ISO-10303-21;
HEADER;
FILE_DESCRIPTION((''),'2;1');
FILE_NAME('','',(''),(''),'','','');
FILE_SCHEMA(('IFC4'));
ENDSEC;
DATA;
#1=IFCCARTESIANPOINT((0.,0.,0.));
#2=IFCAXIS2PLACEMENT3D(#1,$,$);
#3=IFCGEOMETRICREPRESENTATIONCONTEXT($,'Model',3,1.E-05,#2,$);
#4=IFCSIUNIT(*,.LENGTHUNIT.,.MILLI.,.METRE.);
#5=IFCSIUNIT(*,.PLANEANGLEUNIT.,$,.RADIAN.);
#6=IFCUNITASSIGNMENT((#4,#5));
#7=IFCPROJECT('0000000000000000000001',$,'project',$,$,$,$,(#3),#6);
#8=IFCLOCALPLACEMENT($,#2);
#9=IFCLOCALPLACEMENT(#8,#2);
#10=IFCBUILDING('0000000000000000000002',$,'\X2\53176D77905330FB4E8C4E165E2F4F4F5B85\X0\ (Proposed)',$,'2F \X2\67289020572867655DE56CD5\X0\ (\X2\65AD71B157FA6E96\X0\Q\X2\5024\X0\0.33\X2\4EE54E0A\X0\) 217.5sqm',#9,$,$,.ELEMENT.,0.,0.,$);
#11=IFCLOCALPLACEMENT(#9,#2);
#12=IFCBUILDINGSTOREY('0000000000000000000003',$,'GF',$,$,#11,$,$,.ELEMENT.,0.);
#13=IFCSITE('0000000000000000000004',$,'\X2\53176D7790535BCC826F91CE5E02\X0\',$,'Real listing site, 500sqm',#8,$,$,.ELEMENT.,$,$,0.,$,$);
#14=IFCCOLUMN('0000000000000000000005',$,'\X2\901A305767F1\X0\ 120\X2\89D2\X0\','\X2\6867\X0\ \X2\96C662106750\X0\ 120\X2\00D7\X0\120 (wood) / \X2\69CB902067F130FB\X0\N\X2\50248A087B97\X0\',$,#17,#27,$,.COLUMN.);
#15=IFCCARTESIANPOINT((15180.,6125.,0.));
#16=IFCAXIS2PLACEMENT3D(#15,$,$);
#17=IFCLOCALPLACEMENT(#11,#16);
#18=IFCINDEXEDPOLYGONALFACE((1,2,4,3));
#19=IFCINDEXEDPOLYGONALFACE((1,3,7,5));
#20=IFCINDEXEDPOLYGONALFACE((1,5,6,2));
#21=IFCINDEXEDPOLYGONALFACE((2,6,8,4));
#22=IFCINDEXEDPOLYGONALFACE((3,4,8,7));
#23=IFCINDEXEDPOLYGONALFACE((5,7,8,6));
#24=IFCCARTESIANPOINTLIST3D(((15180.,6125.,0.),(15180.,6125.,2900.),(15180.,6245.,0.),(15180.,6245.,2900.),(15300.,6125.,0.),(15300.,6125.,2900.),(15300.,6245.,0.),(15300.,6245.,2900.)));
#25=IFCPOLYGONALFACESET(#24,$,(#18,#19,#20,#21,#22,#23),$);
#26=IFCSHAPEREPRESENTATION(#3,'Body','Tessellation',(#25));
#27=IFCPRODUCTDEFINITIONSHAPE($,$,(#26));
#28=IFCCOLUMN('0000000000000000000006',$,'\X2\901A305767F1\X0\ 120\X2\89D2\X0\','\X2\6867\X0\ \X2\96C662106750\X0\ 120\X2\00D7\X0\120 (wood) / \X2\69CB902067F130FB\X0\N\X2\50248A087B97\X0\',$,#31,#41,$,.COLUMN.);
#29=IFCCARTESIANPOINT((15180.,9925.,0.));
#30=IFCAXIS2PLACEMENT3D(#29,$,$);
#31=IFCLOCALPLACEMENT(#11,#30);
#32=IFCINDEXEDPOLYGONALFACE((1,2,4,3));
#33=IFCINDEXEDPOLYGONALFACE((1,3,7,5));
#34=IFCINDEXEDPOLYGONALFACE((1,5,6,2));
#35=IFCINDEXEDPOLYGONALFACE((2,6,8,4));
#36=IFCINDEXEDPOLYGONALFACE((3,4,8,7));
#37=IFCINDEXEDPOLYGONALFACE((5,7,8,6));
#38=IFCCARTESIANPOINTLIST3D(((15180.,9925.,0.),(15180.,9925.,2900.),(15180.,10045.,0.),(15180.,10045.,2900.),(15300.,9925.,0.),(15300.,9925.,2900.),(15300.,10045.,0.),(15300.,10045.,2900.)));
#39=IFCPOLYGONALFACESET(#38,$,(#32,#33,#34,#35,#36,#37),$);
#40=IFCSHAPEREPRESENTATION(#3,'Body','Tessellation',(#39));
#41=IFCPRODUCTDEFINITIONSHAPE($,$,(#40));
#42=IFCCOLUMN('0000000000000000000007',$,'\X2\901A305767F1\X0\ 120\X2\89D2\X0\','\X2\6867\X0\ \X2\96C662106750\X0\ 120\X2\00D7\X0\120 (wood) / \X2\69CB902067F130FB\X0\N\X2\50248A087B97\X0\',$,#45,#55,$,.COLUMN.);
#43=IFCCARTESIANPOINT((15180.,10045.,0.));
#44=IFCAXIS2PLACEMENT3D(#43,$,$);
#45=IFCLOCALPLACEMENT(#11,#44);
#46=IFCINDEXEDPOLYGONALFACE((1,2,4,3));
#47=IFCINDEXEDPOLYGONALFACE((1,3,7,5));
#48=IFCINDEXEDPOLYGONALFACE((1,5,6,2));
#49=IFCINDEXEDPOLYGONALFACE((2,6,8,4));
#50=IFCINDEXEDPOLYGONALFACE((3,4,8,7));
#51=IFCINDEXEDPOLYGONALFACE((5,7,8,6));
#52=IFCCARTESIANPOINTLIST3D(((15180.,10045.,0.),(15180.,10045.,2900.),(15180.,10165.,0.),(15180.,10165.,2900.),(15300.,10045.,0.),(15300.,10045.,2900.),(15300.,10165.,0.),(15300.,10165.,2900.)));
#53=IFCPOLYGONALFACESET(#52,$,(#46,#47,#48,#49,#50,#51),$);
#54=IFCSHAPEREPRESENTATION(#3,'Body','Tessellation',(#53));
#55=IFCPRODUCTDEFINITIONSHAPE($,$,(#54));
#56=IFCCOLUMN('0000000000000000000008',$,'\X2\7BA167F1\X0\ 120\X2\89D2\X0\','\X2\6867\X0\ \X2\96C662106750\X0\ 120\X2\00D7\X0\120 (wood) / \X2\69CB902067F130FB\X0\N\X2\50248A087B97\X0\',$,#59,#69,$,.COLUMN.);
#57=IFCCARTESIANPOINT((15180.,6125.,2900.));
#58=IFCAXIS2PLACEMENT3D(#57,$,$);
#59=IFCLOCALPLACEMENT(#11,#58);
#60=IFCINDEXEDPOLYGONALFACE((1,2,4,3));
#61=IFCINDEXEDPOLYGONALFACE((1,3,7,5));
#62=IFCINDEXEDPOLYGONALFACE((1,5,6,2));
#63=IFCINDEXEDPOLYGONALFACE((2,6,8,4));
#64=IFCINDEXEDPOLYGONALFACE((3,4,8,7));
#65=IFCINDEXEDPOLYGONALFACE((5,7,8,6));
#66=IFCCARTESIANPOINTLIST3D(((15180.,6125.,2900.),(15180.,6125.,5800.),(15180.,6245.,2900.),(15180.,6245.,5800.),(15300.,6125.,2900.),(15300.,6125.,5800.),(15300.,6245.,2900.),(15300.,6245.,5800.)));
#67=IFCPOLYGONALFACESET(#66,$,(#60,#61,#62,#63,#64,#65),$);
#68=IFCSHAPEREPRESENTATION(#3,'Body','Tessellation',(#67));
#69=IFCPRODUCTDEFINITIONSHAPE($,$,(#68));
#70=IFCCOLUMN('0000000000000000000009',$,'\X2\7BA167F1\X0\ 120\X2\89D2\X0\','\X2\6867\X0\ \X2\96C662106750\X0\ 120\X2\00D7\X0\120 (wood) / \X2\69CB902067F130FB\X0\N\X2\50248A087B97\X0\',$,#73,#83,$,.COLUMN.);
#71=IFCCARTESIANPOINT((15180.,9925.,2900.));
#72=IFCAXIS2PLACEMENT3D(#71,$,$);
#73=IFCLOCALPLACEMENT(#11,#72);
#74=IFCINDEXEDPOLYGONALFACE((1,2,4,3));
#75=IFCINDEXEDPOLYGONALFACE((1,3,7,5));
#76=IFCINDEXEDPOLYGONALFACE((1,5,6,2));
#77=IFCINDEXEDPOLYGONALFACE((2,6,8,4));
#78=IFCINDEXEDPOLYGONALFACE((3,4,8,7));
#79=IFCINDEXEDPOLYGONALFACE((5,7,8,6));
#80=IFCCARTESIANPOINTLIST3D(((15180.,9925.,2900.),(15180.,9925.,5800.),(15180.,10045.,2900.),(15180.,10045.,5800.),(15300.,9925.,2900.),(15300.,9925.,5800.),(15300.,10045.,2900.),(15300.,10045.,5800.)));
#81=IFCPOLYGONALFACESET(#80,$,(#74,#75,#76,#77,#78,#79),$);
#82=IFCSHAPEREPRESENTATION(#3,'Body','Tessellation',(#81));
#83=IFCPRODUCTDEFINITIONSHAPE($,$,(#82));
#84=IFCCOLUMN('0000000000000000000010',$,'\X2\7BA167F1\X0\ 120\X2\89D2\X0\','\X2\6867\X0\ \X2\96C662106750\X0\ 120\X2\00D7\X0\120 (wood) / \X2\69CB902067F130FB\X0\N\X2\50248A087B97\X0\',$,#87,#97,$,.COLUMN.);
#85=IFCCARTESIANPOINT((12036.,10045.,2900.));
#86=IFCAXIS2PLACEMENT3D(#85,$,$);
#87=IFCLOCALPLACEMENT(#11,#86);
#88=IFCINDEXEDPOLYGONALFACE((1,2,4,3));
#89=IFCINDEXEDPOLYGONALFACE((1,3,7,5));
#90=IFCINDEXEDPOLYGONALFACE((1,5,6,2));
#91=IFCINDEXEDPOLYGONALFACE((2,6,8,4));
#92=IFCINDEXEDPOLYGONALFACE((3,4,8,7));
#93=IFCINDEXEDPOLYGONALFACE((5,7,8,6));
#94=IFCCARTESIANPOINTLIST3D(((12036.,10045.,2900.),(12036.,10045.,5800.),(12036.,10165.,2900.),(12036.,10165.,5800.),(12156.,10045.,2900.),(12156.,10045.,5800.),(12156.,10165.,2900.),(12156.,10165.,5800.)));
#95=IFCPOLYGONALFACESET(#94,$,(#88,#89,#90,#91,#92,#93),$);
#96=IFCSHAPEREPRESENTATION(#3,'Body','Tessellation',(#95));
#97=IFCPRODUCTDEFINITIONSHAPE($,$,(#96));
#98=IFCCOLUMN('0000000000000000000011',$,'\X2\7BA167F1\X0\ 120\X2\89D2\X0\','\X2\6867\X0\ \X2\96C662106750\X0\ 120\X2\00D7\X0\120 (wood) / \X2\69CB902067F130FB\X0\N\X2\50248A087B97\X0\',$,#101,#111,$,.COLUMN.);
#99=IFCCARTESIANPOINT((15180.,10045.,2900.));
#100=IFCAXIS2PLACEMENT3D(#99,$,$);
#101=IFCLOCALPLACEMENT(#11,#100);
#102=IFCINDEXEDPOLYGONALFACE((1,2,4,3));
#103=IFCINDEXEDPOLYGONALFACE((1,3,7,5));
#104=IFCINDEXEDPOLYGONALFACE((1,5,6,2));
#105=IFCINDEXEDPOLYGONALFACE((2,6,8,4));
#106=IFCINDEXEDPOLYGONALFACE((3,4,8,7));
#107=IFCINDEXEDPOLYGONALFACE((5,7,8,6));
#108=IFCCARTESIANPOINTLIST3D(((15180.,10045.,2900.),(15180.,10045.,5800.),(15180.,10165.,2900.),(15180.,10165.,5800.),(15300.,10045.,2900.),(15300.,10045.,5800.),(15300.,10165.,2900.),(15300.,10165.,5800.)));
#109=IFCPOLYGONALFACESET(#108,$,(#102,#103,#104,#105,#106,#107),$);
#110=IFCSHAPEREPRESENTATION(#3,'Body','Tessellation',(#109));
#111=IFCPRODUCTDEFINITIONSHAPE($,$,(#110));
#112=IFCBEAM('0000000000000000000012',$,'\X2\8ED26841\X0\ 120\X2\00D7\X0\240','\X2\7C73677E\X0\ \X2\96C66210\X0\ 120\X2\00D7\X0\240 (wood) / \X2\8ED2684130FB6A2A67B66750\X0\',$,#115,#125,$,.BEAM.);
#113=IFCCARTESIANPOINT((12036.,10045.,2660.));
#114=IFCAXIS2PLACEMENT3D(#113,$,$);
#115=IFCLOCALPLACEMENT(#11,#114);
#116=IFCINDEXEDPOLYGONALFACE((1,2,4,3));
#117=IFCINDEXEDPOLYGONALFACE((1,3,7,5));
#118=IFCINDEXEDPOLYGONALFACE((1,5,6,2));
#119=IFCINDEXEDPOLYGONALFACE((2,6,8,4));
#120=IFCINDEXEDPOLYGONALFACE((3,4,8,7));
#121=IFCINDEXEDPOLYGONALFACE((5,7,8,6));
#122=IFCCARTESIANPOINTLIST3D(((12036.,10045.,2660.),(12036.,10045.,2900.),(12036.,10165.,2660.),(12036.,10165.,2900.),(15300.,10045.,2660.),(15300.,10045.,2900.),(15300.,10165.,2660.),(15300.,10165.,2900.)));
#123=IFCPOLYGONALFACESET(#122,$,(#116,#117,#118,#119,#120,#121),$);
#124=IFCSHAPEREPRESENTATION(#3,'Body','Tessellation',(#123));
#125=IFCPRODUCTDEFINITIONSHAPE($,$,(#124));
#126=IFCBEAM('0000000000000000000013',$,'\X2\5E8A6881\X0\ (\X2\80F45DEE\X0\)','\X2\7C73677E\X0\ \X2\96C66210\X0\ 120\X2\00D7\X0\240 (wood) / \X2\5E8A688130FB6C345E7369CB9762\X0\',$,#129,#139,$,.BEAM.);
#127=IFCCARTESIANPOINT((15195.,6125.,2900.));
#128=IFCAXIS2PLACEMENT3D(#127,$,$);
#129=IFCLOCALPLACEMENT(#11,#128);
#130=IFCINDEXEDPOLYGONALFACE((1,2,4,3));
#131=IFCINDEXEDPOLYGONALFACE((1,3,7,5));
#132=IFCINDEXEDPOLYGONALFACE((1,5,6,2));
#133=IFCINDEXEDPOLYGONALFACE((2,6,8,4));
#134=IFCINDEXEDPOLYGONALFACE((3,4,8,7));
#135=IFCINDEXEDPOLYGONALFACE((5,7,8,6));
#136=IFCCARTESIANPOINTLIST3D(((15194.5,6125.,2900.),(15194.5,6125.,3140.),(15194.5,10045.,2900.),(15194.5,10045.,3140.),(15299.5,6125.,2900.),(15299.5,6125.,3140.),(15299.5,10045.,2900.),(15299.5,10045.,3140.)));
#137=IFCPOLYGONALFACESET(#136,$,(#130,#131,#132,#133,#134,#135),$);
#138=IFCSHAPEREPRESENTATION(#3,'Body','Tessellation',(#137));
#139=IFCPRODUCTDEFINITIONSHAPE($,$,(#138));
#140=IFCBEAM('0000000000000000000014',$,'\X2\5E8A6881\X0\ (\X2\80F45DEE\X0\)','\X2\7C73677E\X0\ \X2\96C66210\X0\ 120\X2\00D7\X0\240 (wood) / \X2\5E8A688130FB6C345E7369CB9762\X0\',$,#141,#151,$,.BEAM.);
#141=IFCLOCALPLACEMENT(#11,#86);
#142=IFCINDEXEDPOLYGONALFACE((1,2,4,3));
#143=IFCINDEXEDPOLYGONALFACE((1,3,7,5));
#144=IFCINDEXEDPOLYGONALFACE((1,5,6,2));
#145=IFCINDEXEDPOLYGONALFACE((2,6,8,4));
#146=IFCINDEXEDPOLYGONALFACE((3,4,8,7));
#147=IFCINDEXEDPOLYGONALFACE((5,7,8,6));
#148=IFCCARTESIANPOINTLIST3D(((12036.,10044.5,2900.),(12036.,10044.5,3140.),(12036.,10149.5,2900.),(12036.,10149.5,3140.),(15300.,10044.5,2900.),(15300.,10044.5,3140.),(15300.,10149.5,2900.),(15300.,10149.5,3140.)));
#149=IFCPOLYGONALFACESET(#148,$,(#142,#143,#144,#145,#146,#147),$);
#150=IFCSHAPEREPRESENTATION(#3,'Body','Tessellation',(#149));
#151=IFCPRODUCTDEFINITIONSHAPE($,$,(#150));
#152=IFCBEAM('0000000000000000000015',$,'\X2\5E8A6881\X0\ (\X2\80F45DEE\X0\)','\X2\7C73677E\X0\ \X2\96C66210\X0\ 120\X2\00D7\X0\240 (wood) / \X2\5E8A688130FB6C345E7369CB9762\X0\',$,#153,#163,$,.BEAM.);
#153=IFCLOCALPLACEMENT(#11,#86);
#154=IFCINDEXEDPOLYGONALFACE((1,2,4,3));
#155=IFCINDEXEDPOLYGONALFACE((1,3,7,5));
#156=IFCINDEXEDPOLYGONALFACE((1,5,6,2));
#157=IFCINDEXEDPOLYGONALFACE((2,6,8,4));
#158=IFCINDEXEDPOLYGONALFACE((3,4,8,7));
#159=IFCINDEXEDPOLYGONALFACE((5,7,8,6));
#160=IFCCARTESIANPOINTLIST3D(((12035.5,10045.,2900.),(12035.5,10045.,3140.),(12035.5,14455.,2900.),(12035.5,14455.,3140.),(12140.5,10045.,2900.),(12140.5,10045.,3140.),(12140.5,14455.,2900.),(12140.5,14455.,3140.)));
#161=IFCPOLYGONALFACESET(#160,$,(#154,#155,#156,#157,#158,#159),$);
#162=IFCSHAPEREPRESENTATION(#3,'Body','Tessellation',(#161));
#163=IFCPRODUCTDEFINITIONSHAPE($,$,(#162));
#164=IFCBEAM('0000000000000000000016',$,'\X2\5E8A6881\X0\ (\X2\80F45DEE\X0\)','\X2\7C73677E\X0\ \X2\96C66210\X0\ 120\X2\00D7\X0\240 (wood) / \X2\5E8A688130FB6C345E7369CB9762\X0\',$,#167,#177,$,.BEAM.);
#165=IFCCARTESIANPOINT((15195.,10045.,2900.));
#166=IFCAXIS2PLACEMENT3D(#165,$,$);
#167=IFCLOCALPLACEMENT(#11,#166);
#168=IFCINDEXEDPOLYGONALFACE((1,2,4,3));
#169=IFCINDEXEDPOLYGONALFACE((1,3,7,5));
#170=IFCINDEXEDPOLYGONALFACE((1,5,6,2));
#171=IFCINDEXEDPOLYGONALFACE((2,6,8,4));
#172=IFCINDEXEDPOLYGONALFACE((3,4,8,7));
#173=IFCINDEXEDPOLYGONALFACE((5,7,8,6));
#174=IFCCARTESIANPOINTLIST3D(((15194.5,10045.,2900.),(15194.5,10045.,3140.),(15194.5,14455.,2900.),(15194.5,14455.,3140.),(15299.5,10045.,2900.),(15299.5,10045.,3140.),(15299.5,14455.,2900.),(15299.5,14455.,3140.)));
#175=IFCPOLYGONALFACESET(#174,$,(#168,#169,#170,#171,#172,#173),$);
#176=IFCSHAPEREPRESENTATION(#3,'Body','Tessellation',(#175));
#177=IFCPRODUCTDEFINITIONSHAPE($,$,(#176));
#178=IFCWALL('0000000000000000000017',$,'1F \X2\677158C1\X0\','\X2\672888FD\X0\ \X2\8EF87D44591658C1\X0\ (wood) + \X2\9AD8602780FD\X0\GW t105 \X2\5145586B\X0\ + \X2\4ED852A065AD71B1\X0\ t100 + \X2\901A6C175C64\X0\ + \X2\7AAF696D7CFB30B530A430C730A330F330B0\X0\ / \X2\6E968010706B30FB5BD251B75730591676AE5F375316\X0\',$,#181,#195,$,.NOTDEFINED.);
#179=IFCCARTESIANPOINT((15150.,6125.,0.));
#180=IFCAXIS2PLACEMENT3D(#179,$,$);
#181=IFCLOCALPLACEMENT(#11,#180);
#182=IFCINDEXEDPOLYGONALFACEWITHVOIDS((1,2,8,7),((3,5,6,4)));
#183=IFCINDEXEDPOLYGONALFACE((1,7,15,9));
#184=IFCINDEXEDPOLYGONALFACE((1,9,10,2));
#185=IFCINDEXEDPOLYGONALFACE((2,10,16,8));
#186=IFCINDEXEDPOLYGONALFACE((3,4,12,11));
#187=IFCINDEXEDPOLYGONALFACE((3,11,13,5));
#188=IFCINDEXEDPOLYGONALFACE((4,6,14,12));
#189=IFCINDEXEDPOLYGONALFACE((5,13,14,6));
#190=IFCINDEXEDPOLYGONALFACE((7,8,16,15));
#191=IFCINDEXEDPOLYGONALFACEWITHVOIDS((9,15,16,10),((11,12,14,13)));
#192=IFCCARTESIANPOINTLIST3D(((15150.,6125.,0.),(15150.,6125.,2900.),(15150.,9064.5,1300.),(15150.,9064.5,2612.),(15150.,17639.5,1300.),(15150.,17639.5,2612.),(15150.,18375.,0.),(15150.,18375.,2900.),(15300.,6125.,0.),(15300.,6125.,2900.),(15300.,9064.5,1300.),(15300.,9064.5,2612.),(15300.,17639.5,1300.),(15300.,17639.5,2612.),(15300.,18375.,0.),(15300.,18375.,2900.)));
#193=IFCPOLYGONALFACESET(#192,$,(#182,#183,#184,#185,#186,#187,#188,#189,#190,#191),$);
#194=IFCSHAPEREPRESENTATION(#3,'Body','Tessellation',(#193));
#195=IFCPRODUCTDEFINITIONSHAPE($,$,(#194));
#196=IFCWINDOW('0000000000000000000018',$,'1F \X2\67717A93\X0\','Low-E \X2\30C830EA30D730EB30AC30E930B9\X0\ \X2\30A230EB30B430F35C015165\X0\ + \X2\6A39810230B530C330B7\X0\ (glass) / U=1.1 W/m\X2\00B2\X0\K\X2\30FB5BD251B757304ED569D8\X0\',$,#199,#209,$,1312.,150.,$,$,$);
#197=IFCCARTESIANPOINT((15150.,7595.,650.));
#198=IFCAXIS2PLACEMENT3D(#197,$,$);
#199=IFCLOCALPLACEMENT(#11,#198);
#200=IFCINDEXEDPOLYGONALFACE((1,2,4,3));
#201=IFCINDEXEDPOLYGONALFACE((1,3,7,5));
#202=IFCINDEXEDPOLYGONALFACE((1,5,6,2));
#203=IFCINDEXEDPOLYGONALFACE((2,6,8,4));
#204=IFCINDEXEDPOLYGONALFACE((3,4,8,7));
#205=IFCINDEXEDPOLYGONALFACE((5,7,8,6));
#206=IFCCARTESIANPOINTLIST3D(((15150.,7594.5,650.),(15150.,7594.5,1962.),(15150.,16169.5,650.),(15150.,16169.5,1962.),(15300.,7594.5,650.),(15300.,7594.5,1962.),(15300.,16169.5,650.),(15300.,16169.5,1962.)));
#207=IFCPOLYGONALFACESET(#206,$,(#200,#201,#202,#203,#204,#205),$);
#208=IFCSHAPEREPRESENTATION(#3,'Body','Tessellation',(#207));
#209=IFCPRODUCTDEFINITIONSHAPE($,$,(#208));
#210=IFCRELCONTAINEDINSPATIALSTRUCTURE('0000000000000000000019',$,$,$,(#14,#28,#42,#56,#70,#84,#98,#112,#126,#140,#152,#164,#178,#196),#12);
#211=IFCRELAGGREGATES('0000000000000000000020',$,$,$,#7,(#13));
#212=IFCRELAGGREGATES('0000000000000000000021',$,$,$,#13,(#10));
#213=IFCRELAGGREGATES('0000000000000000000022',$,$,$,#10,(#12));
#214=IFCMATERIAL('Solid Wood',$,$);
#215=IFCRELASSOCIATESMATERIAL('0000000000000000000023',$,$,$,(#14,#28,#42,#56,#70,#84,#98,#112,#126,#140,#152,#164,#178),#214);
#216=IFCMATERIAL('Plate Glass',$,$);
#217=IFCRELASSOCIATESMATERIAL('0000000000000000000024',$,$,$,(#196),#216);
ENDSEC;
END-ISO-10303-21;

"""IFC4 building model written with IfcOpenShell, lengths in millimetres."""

from ifc_helpers import new_model, si_unit, frame, frame_2d, origin, place, context, project, spatial, rectangle, extrude, material, element, fill, save


model = new_model("IFC4")

# Units and contexts
model_context = context("Model", 3, precision=1e-05, world=origin())
ifc_project = project(units=[si_unit("LENGTHUNIT", "METRE", prefix="MILLI"), si_unit("PLANEANGLEUNIT", "RADIAN")], contexts=[model_context])

# Site, building, storey
site_placement = place(None, origin())
site = spatial("IfcSite", under=ifc_project, at=site_placement, Name="北海道富良野市", ObjectType="Real listing site, 500sqm", CompositionType="ELEMENT", RefElevation=0.0)
building_placement = place(site_placement, origin())
building = spatial("IfcBuilding", under=site, at=building_placement, Name="北海道・二世帯住宅 (Proposed)", ObjectType="2F 木造在来工法 (断熱基準Q値0.33以上) 217.5sqm", CompositionType="ELEMENT", ElevationOfRefHeight=0.0, ElevationOfTerrain=0.0)
storey_placement = place(building_placement, origin())
storey = spatial("IfcBuildingStorey", under=building, at=storey_placement, Name="GF", CompositionType="ELEMENT", Elevation=0.0)

# Columns
ifc_material_1 = material(Name="Solid Wood")
column_1_placement = place(storey_placement, frame((15180.0, 6125.0, 0.0)))
element("IfcColumn", 1, at=column_1_placement, inside=storey, material=ifc_material_1, Name="通し柱 120角", Description="桧 集成材 120×120 (wood) / 構造柱・N値計算", PredefinedType="COLUMN", context=model_context, shape_type="SweptSolid", body=[
    extrude(rectangle(XDim=120.0, YDim=120.0, at=frame_2d((60.0, 60.0))), frame((15180.0, 6125.0, 0.0)), (0.0, 0.0, 1.0), 2900.0),
])
column_2_placement = place(storey_placement, frame((15180.0, 9925.0, 0.0)))
element("IfcColumn", 2, at=column_2_placement, inside=storey, material=ifc_material_1, Name="通し柱 120角", Description="桧 集成材 120×120 (wood) / 構造柱・N値計算", PredefinedType="COLUMN", context=model_context, shape_type="SweptSolid", body=[
    extrude(rectangle(XDim=120.0, YDim=120.0, at=frame_2d((60.0, 60.0))), frame((15180.0, 9925.0, 0.0)), (0.0, 0.0, 1.0), 2900.0),
])
column_3_placement = place(storey_placement, frame((15180.0, 10045.0, 0.0)))
element("IfcColumn", 3, at=column_3_placement, inside=storey, material=ifc_material_1, Name="通し柱 120角", Description="桧 集成材 120×120 (wood) / 構造柱・N値計算", PredefinedType="COLUMN", context=model_context, shape_type="SweptSolid", body=[
    extrude(rectangle(XDim=120.0, YDim=120.0, at=frame_2d((60.0, 60.0))), frame((15180.0, 10045.0, 0.0)), (0.0, 0.0, 1.0), 2900.0),
])
column_4_placement = place(storey_placement, frame((15180.0, 6125.0, 2900.0)))
element("IfcColumn", 4, at=column_4_placement, inside=storey, material=ifc_material_1, Name="管柱 120角", Description="桧 集成材 120×120 (wood) / 構造柱・N値計算", PredefinedType="COLUMN", context=model_context, shape_type="SweptSolid", body=[
    extrude(rectangle(XDim=120.0, YDim=120.0, at=frame_2d((60.0, 60.0))), frame((15180.0, 6125.0, 2900.0)), (0.0, 0.0, 1.0), 2900.0),
])
column_5_placement = place(storey_placement, frame((15180.0, 9925.0, 2900.0)))
element("IfcColumn", 5, at=column_5_placement, inside=storey, material=ifc_material_1, Name="管柱 120角", Description="桧 集成材 120×120 (wood) / 構造柱・N値計算", PredefinedType="COLUMN", context=model_context, shape_type="SweptSolid", body=[
    extrude(rectangle(XDim=120.0, YDim=120.0, at=frame_2d((60.0, 60.0))), frame((15180.0, 9925.0, 2900.0)), (0.0, 0.0, 1.0), 2900.0),
])
column_6_placement = place(storey_placement, frame((12036.0, 10045.0, 2900.0)))
element("IfcColumn", 6, at=column_6_placement, inside=storey, material=ifc_material_1, Name="管柱 120角", Description="桧 集成材 120×120 (wood) / 構造柱・N値計算", PredefinedType="COLUMN", context=model_context, shape_type="SweptSolid", body=[
    extrude(rectangle(XDim=120.0, YDim=120.0, at=frame_2d((60.0, 60.0))), frame((12036.0, 10045.0, 2900.0)), (0.0, 0.0, 1.0), 2900.0),
])
column_7_placement = place(storey_placement, frame((15180.0, 10045.0, 2900.0)))
element("IfcColumn", 7, at=column_7_placement, inside=storey, material=ifc_material_1, Name="管柱 120角", Description="桧 集成材 120×120 (wood) / 構造柱・N値計算", PredefinedType="COLUMN", context=model_context, shape_type="SweptSolid", body=[
    extrude(rectangle(XDim=120.0, YDim=120.0, at=frame_2d((60.0, 60.0))), frame((15180.0, 10045.0, 2900.0)), (0.0, 0.0, 1.0), 2900.0),
])

# Beams
beam_1_placement = place(storey_placement, frame((12036.0, 10045.0, 2660.0)))
element("IfcBeam", 8, at=beam_1_placement, inside=storey, material=ifc_material_1, Name="軒桁 120×240", Description="米松 集成 120×240 (wood) / 軒桁・横架材", PredefinedType="BEAM", context=model_context, shape_type="SweptSolid", body=[
    extrude(rectangle(XDim=3264.0, YDim=120.0, at=frame_2d((1632.0, 60.0))), frame((12036.0, 10045.0, 2660.0)), (0.0, 0.0, 1.0), 240.0),
])
beam_2_placement = place(storey_placement, frame((15195.0, 6125.0, 2900.0)))
element("IfcBeam", 9, at=beam_2_placement, inside=storey, material=ifc_material_1, Name="床梁 (胴差)", Description="米松 集成 120×240 (wood) / 床梁・水平構面", PredefinedType="BEAM", context=model_context, shape_type="SweptSolid", body=[
    extrude(rectangle(XDim=105.0, YDim=3920.0, at=frame_2d((52.0, 1960.0))), frame((15195.0, 6125.0, 2900.0)), (0.0, 0.0, 1.0), 240.0),
])
beam_3_placement = place(storey_placement, frame((12036.0, 10045.0, 2900.0)))
element("IfcBeam", 10, at=beam_3_placement, inside=storey, material=ifc_material_1, Name="床梁 (胴差)", Description="米松 集成 120×240 (wood) / 床梁・水平構面", PredefinedType="BEAM", context=model_context, shape_type="SweptSolid", body=[
    extrude(rectangle(XDim=3264.0, YDim=105.0, at=frame_2d((1632.0, 52.0))), frame((12036.0, 10045.0, 2900.0)), (0.0, 0.0, 1.0), 240.0),
])
beam_4_placement = place(storey_placement, frame((12036.0, 10045.0, 2900.0)))
element("IfcBeam", 11, at=beam_4_placement, inside=storey, material=ifc_material_1, Name="床梁 (胴差)", Description="米松 集成 120×240 (wood) / 床梁・水平構面", PredefinedType="BEAM", context=model_context, shape_type="SweptSolid", body=[
    extrude(rectangle(XDim=105.0, YDim=4410.0, at=frame_2d((52.0, 2205.0))), frame((12036.0, 10045.0, 2900.0)), (0.0, 0.0, 1.0), 240.0),
])
beam_5_placement = place(storey_placement, frame((15195.0, 10045.0, 2900.0)))
element("IfcBeam", 12, at=beam_5_placement, inside=storey, material=ifc_material_1, Name="床梁 (胴差)", Description="米松 集成 120×240 (wood) / 床梁・水平構面", PredefinedType="BEAM", context=model_context, shape_type="SweptSolid", body=[
    extrude(rectangle(XDim=105.0, YDim=4410.0, at=frame_2d((52.0, 2205.0))), frame((15195.0, 10045.0, 2900.0)), (0.0, 0.0, 1.0), 240.0),
])

# Wall, opening, window
wall_1_placement = place(storey_placement, frame((15150.0, 6125.0, 0.0)))
wall_1 = element("IfcWall", 13, at=wall_1_placement, inside=storey, material=ifc_material_1, Name="1F 東壁", Description="木製 軸組外壁 (wood) + 高性能GW t105 充填 + 付加断熱 t100 + 通気層 + 窯業系サイディング / 準耐火・寒冷地外皮強化", PredefinedType="NOTDEFINED", context=model_context, shape_type="SweptSolid", body=[
    extrude(rectangle(XDim=150.0, YDim=12250.0, at=frame_2d((75.0, 6125.0))), frame((15150.0, 6125.0, 0.0)), (0.0, 0.0, 1.0), 2900.0),
])
opening_1_placement = place(storey_placement, frame((15150.0, 7595.0, 650.0)))
opening_1 = element("IfcOpeningElement", 14, at=opening_1_placement, cuts=wall_1, PredefinedType="NOTDEFINED", context=model_context, shape_type="SweptSolid", body=[
    extrude(rectangle(XDim=150.0, YDim=8575.0, at=frame_2d((75.0, 4287.0))), frame((15150.0, 7595.0, 650.0)), (0.0, 0.0, 1.0), 1312.0),
])
ifc_material_2 = material(Name="Plate Glass")
window_1_placement = place(storey_placement, frame((15150.0, 7595.0, 650.0)))
window_1 = element("IfcWindow", 15, at=window_1_placement, inside=storey, material=ifc_material_2, Name="1F 東窓", Description="Low-E トリプルガラス アルゴン封入 + 樹脂サッシ (glass) / U=1.1 W/m²K・寒冷地仕様", OverallHeight=1312.0, OverallWidth=150.0, context=model_context, shape_type="SweptSolid", body=[
    extrude(rectangle(XDim=150.0, YDim=8575.0, at=frame_2d((75.0, 4287.0))), frame((15150.0, 7595.0, 650.0)), (0.0, 0.0, 1.0), 1312.0),
])
fill(opening_1, window_1)

save(model, "model.ifc")
